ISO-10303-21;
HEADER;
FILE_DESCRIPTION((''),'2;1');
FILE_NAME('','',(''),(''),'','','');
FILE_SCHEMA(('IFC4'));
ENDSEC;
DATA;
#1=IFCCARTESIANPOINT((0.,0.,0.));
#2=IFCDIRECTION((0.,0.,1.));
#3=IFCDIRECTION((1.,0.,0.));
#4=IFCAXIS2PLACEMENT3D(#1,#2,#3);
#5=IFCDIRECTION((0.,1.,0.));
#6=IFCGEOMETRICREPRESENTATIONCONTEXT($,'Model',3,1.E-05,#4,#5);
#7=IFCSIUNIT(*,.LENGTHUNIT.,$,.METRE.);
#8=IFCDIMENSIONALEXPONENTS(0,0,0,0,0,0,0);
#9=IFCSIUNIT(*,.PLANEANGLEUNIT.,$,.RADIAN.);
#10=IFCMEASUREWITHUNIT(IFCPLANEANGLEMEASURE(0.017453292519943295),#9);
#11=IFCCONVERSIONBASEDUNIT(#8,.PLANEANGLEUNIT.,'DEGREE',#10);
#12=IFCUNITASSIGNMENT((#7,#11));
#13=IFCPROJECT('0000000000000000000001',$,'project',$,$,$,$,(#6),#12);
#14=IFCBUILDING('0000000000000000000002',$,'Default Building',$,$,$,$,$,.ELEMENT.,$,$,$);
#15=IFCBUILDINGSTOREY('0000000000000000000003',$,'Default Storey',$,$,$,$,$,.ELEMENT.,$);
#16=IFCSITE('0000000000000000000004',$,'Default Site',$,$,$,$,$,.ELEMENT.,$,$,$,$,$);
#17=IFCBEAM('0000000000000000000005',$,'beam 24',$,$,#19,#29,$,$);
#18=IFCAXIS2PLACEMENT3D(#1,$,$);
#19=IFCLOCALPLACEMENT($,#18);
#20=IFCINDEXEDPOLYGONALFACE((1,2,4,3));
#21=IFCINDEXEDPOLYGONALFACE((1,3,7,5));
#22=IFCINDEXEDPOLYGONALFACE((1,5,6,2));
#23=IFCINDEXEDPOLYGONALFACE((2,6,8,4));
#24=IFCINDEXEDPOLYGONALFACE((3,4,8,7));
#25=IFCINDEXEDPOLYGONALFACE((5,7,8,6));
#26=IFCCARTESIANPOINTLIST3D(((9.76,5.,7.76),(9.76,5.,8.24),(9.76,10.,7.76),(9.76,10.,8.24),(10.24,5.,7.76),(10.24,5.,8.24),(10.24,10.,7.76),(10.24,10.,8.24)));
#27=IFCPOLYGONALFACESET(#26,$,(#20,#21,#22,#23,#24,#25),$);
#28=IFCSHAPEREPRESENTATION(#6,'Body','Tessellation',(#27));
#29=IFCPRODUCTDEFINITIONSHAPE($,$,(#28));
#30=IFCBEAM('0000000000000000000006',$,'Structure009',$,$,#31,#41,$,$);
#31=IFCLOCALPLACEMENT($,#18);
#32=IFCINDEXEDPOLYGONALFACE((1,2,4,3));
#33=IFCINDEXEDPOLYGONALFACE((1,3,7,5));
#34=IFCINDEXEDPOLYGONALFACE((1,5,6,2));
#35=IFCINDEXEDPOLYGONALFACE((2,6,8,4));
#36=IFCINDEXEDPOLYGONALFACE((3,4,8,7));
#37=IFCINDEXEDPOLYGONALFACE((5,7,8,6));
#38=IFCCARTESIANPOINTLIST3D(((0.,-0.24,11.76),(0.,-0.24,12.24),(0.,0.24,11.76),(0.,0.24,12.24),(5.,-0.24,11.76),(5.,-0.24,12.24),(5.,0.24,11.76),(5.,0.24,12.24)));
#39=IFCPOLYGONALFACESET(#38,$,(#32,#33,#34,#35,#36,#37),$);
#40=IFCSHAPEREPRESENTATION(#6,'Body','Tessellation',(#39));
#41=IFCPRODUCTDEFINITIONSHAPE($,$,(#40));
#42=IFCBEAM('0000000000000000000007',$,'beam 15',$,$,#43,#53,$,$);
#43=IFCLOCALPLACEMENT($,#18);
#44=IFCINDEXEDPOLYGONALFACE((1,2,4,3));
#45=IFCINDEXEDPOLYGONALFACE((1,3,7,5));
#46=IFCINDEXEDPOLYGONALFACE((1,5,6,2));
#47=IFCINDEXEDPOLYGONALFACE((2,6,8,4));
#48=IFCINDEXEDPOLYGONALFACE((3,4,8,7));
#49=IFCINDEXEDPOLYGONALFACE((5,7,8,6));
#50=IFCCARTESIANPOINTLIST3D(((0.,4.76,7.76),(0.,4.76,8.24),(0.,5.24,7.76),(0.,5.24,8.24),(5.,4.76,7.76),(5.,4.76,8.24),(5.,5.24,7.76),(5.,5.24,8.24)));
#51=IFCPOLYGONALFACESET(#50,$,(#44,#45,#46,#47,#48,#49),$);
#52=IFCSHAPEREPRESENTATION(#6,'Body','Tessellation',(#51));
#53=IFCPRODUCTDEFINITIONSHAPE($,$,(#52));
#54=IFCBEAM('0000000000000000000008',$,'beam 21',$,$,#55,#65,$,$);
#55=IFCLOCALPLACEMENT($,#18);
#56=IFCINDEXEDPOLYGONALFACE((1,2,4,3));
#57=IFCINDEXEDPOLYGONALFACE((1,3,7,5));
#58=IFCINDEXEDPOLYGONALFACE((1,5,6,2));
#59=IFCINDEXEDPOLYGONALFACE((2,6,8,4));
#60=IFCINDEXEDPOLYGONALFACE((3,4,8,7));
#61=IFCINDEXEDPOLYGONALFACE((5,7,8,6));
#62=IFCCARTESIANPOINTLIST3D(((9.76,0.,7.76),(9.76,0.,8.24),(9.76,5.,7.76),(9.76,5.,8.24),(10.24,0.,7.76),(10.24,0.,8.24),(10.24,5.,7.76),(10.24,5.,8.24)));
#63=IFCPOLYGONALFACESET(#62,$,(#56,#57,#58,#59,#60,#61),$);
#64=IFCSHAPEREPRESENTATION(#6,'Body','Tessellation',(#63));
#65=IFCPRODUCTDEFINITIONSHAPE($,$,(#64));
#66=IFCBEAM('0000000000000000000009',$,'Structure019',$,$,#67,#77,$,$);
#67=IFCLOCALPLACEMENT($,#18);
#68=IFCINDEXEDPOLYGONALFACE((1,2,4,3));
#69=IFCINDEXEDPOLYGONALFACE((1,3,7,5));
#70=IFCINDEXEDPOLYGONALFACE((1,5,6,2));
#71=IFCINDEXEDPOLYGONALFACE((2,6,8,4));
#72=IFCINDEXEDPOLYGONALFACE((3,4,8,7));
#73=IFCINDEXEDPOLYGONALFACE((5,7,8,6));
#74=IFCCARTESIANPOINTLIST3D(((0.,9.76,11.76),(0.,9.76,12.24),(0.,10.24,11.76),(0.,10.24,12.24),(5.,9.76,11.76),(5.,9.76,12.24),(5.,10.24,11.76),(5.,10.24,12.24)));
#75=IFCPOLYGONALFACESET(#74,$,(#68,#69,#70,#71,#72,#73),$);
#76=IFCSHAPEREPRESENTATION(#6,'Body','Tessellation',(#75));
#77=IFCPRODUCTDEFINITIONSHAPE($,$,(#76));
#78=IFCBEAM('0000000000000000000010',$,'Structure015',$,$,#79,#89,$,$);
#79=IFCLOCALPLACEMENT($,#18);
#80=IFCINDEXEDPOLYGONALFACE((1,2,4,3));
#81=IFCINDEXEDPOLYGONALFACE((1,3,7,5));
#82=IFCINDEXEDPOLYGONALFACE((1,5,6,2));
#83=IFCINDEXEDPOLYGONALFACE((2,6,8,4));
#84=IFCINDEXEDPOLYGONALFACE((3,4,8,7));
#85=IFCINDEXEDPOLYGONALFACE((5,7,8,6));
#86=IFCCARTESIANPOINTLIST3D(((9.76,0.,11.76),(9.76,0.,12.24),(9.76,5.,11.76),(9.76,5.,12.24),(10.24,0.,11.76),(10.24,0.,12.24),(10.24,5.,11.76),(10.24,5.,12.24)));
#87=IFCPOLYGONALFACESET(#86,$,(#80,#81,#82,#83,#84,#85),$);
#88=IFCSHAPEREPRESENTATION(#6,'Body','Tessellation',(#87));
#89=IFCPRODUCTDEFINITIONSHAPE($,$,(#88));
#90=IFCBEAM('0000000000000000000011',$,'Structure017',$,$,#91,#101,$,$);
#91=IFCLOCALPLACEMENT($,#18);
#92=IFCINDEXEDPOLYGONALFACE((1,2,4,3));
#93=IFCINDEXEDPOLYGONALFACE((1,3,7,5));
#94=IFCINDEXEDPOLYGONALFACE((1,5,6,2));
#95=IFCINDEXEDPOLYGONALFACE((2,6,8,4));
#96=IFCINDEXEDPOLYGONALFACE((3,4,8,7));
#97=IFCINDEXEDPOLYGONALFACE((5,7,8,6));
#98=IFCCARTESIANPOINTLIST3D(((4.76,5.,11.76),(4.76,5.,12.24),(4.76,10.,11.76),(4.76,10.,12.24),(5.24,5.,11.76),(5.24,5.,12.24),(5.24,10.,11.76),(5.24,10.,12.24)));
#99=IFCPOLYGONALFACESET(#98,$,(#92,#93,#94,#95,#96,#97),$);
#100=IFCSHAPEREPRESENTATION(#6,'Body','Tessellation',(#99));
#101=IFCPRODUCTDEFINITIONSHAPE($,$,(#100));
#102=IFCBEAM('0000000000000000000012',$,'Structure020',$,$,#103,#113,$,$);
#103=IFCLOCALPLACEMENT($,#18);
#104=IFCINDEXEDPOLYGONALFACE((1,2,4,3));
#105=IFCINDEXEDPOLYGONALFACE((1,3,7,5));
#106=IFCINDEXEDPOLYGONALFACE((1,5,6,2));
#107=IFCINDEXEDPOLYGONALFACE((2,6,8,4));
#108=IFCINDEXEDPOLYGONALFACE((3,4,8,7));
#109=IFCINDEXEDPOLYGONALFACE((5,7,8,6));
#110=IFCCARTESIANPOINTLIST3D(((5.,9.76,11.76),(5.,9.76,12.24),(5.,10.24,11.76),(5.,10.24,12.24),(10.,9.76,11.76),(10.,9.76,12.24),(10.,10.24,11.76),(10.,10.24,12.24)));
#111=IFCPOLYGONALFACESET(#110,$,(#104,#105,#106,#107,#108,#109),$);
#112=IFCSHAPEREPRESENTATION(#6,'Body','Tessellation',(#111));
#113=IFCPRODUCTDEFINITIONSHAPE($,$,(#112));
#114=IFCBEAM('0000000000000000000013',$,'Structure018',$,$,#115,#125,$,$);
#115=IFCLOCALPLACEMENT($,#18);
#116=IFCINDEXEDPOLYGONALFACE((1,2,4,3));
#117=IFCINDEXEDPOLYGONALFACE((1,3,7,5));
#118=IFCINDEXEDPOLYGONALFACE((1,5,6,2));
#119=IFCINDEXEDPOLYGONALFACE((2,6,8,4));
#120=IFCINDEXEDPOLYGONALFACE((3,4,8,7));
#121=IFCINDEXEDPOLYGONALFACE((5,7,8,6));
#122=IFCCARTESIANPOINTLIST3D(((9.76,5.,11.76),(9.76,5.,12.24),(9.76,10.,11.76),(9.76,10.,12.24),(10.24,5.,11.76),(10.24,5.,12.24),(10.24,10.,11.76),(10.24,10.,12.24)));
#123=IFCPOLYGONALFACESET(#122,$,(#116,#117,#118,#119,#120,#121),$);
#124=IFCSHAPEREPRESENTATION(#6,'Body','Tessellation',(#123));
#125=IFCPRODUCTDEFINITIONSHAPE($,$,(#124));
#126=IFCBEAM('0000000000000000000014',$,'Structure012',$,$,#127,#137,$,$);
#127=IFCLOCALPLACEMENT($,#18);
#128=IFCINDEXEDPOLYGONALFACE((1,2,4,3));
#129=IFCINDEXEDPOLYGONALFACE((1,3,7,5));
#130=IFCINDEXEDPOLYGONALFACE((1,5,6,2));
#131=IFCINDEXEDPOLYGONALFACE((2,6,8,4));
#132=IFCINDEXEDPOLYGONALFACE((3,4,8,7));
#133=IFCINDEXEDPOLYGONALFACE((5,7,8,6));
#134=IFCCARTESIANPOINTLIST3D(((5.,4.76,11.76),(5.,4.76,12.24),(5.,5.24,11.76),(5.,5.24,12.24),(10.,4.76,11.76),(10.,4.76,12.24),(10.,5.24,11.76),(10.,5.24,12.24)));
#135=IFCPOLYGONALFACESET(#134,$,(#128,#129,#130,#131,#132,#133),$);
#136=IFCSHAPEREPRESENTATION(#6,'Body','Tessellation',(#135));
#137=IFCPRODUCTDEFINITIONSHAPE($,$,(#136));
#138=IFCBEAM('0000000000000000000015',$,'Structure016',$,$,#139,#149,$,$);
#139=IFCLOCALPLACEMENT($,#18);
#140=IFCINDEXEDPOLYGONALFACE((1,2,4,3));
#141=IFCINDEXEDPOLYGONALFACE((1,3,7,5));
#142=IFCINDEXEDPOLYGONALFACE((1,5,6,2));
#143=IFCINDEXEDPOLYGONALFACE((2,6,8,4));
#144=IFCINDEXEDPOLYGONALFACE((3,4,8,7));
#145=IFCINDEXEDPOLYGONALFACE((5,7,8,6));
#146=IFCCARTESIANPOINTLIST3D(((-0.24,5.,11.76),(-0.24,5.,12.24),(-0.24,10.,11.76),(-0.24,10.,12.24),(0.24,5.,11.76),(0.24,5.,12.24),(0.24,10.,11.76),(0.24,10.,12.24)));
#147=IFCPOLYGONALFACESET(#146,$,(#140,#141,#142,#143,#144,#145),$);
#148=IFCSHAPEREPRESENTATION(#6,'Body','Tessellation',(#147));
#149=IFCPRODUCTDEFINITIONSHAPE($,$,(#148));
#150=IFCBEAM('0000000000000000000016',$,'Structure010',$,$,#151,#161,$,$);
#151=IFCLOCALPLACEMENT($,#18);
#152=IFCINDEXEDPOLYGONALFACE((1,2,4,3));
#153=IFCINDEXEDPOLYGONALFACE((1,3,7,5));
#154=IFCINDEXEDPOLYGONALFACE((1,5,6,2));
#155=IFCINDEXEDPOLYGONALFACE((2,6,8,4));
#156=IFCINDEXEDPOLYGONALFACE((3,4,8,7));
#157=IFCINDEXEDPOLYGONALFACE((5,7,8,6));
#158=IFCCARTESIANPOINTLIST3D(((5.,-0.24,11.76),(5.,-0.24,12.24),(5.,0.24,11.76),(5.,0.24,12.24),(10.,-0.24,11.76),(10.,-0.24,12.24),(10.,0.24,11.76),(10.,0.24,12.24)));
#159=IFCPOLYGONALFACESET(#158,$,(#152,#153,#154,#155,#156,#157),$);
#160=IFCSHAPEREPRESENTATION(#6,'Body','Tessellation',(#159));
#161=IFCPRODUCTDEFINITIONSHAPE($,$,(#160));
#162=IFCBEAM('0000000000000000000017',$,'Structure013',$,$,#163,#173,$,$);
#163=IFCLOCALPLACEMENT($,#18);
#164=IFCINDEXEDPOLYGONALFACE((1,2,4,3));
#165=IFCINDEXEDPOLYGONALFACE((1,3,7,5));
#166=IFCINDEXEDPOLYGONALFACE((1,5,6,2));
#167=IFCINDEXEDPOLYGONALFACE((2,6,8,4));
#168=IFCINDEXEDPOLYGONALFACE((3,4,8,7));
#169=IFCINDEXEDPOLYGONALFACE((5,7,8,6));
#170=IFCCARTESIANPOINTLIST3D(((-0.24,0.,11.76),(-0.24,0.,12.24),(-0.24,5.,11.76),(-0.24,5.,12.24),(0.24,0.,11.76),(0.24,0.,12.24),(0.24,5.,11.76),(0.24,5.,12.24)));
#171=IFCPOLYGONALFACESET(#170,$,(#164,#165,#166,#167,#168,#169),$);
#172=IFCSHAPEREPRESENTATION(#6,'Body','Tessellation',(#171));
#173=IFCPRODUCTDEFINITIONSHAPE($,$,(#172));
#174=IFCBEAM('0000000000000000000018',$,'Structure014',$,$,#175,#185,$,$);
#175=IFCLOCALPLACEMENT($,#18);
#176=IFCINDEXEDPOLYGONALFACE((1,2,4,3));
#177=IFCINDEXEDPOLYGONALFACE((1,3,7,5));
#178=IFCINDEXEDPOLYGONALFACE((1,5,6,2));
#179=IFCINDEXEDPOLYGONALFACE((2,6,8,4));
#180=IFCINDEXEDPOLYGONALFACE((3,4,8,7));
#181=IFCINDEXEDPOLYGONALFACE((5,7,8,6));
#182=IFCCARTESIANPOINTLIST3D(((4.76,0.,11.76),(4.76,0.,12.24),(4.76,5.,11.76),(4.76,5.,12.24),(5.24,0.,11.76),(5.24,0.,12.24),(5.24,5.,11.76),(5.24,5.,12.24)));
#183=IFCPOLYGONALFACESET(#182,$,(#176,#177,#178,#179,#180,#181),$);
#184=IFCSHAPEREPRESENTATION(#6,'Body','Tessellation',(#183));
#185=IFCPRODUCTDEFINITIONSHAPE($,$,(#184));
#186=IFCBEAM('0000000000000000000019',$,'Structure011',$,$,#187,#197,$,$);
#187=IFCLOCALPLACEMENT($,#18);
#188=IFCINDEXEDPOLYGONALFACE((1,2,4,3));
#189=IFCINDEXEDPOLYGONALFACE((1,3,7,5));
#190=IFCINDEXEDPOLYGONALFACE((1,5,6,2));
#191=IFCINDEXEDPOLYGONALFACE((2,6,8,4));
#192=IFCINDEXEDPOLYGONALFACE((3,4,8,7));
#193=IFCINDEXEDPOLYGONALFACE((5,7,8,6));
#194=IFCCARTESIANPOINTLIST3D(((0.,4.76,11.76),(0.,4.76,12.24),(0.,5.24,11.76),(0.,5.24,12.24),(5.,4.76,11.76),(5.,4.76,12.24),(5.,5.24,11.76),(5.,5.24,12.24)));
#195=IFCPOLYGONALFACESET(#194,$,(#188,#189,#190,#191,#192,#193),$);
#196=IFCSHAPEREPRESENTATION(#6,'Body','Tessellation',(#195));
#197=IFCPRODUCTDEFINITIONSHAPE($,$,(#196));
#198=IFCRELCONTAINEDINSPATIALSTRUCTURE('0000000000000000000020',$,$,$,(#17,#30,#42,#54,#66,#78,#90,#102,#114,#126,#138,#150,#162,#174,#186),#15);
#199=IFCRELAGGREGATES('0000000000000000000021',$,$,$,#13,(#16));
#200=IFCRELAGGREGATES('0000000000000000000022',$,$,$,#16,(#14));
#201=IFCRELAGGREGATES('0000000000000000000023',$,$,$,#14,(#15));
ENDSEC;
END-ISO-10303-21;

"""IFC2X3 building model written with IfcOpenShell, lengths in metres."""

from ifc_helpers import new_model, entity, si_unit, converted_unit, direction, frame, origin_with_axes, place, context, project, spatial, polyline, outline, extrude, element, save


model = new_model("IFC2X3")

# Units and contexts
model_context = context("Model", 3, precision=1e-05, world=origin_with_axes(), true_north=direction((0.0, 1.0, 0.0)))
ifc_project = project(units=[si_unit("LENGTHUNIT", "METRE"), converted_unit("PLANEANGLEUNIT", "DEGREE", entity("IfcPlaneAngleMeasure", 0.017453292519943295), si_unit("PLANEANGLEUNIT", "RADIAN"), dimensions=[0, 0, 0, 0, 0, 0, 0])], contexts=[model_context])

# Site, building, storey
site = spatial("IfcSite", under=ifc_project, Name="Default Site", CompositionType="ELEMENT")
building = spatial("IfcBuilding", under=site, Name="Default Building", CompositionType="ELEMENT")
storey = spatial("IfcBuildingStorey", under=building, Name="Default Storey", CompositionType="ELEMENT")

# Shared definitions
placement = place(None, origin_with_axes())

# Beams
element("IfcBeam", 1, at=placement, inside=storey, Name="beam 24", context=model_context, shape_type="SweptSolid", body=[
    extrude(outline(polyline([(0.24, -0.24), (0.24, 0.24), (-0.24, 0.24), (-0.24, -0.24), (0.24, -0.24)])), frame((10.0, 5.0, 8.0), z_axis=(0.0, 1.0, 0.0), x_axis=(0.0, 0.0, -1.0)), (0.0, 0.0, 1.0), 5.0),
])
element("IfcBeam", 2, at=placement, inside=storey, Name="Structure009", context=model_context, shape_type="SweptSolid", body=[
    extrude(outline(polyline([(0.24, -0.24), (0.24, 0.24), (-0.24, 0.24), (-0.24, -0.24), (0.24, -0.24)])), frame((0.0, 0.0, 12.0), z_axis=(1.0, 0.0, 0.0), x_axis=(0.0, 0.0, -1.0)), (0.0, 0.0, 1.0), 5.0),
])
element("IfcBeam", 3, at=placement, inside=storey, Name="beam 15", context=model_context, shape_type="SweptSolid", body=[
    extrude(outline(polyline([(0.24, -0.24), (0.24, 0.24), (-0.24, 0.24), (-0.24, -0.24), (0.24, -0.24)])), frame((0.0, 5.0, 8.0), z_axis=(1.0, 0.0, 0.0), x_axis=(0.0, 0.0, -1.0)), (0.0, 0.0, 1.0), 5.0),
])
element("IfcBeam", 4, at=placement, inside=storey, Name="beam 21", context=model_context, shape_type="SweptSolid", body=[
    extrude(outline(polyline([(0.24, -0.24), (0.24, 0.24), (-0.24, 0.24), (-0.24, -0.24), (0.24, -0.24)])), frame((10.0, 0.0, 8.0), z_axis=(0.0, 1.0, 0.0), x_axis=(0.0, 0.0, -1.0)), (0.0, 0.0, 1.0), 5.0),
])
element("IfcBeam", 5, at=placement, inside=storey, Name="Structure019", context=model_context, shape_type="SweptSolid", body=[
    extrude(outline(polyline([(0.24, -0.24), (0.24, 0.24), (-0.24, 0.24), (-0.24, -0.24), (0.24, -0.24)])), frame((0.0, 10.0, 12.0), z_axis=(1.0, 0.0, 0.0), x_axis=(0.0, 0.0, -1.0)), (0.0, 0.0, 1.0), 5.0),
])
element("IfcBeam", 6, at=placement, inside=storey, Name="Structure015", context=model_context, shape_type="SweptSolid", body=[
    extrude(outline(polyline([(0.24, -0.24), (0.24, 0.24), (-0.24, 0.24), (-0.24, -0.24), (0.24, -0.24)])), frame((10.0, 5.0, 12.0), z_axis=(0.0, -1.0, 0.0), x_axis=(0.0, 0.0, -1.0)), (0.0, 0.0, 1.0), 5.0),
])
element("IfcBeam", 7, at=placement, inside=storey, Name="Structure017", context=model_context, shape_type="SweptSolid", body=[
    extrude(outline(polyline([(0.24, -0.24), (0.24, 0.24), (-0.24, 0.24), (-0.24, -0.24), (0.24, -0.24)])), frame((5.0, 10.0, 12.0), z_axis=(0.0, -1.0, 0.0), x_axis=(0.0, 0.0, -1.0)), (0.0, 0.0, 1.0), 5.0),
])
element("IfcBeam", 8, at=placement, inside=storey, Name="Structure020", context=model_context, shape_type="SweptSolid", body=[
    extrude(outline(polyline([(0.24, -0.24), (0.24, 0.24), (-0.24, 0.24), (-0.24, -0.24), (0.24, -0.24)])), frame((5.0, 10.0, 12.0), z_axis=(1.0, 0.0, 0.0), x_axis=(0.0, 0.0, -1.0)), (0.0, 0.0, 1.0), 5.0),
])
element("IfcBeam", 9, at=placement, inside=storey, Name="Structure018", context=model_context, shape_type="SweptSolid", body=[
    extrude(outline(polyline([(0.24, -0.24), (0.24, 0.24), (-0.24, 0.24), (-0.24, -0.24), (0.24, -0.24)])), frame((10.0, 10.0, 12.0), z_axis=(0.0, -1.0, 0.0), x_axis=(0.0, 0.0, -1.0)), (0.0, 0.0, 1.0), 5.0),
])
element("IfcBeam", 10, at=placement, inside=storey, Name="Structure012", context=model_context, shape_type="SweptSolid", body=[
    extrude(outline(polyline([(0.24, -0.24), (0.24, 0.24), (-0.24, 0.24), (-0.24, -0.24), (0.24, -0.24)])), frame((5.0, 5.0, 12.0), z_axis=(1.0, 0.0, 0.0), x_axis=(0.0, 0.0, -1.0)), (0.0, 0.0, 1.0), 5.0),
])
element("IfcBeam", 11, at=placement, inside=storey, Name="Structure016", context=model_context, shape_type="SweptSolid", body=[
    extrude(outline(polyline([(0.24, -0.24), (0.24, 0.24), (-0.24, 0.24), (-0.24, -0.24), (0.24, -0.24)])), frame((0.0, 10.0, 12.0), z_axis=(0.0, -1.0, 0.0), x_axis=(0.0, 0.0, -1.0)), (0.0, 0.0, 1.0), 5.0),
])
element("IfcBeam", 12, at=placement, inside=storey, Name="Structure010", context=model_context, shape_type="SweptSolid", body=[
    extrude(outline(polyline([(0.24, -0.24), (0.24, 0.24), (-0.24, 0.24), (-0.24, -0.24), (0.24, -0.24)])), frame((5.0, 0.0, 12.0), z_axis=(1.0, 0.0, 0.0), x_axis=(0.0, 0.0, -1.0)), (0.0, 0.0, 1.0), 5.0),
])
element("IfcBeam", 13, at=placement, inside=storey, Name="Structure013", context=model_context, shape_type="SweptSolid", body=[
    extrude(outline(polyline([(0.24, -0.24), (0.24, 0.24), (-0.24, 0.24), (-0.24, -0.24), (0.24, -0.24)])), frame((0.0, 5.0, 12.0), z_axis=(0.0, -1.0, 0.0), x_axis=(0.0, 0.0, -1.0)), (0.0, 0.0, 1.0), 5.0),
])
element("IfcBeam", 14, at=placement, inside=storey, Name="Structure014", context=model_context, shape_type="SweptSolid", body=[
    extrude(outline(polyline([(0.24, -0.24), (0.24, 0.24), (-0.24, 0.24), (-0.24, -0.24), (0.24, -0.24)])), frame((5.0, 5.0, 12.0), z_axis=(0.0, -1.0, 0.0), x_axis=(0.0, 0.0, -1.0)), (0.0, 0.0, 1.0), 5.0),
])
element("IfcBeam", 15, at=placement, inside=storey, Name="Structure011", context=model_context, shape_type="SweptSolid", body=[
    extrude(outline(polyline([(0.24, -0.24), (0.24, 0.24), (-0.24, 0.24), (-0.24, -0.24), (0.24, -0.24)])), frame((0.0, 5.0, 12.0), z_axis=(1.0, 0.0, 0.0), x_axis=(0.0, 0.0, -1.0)), (0.0, 0.0, 1.0), 5.0),
])

save(model, "model.ifc")
